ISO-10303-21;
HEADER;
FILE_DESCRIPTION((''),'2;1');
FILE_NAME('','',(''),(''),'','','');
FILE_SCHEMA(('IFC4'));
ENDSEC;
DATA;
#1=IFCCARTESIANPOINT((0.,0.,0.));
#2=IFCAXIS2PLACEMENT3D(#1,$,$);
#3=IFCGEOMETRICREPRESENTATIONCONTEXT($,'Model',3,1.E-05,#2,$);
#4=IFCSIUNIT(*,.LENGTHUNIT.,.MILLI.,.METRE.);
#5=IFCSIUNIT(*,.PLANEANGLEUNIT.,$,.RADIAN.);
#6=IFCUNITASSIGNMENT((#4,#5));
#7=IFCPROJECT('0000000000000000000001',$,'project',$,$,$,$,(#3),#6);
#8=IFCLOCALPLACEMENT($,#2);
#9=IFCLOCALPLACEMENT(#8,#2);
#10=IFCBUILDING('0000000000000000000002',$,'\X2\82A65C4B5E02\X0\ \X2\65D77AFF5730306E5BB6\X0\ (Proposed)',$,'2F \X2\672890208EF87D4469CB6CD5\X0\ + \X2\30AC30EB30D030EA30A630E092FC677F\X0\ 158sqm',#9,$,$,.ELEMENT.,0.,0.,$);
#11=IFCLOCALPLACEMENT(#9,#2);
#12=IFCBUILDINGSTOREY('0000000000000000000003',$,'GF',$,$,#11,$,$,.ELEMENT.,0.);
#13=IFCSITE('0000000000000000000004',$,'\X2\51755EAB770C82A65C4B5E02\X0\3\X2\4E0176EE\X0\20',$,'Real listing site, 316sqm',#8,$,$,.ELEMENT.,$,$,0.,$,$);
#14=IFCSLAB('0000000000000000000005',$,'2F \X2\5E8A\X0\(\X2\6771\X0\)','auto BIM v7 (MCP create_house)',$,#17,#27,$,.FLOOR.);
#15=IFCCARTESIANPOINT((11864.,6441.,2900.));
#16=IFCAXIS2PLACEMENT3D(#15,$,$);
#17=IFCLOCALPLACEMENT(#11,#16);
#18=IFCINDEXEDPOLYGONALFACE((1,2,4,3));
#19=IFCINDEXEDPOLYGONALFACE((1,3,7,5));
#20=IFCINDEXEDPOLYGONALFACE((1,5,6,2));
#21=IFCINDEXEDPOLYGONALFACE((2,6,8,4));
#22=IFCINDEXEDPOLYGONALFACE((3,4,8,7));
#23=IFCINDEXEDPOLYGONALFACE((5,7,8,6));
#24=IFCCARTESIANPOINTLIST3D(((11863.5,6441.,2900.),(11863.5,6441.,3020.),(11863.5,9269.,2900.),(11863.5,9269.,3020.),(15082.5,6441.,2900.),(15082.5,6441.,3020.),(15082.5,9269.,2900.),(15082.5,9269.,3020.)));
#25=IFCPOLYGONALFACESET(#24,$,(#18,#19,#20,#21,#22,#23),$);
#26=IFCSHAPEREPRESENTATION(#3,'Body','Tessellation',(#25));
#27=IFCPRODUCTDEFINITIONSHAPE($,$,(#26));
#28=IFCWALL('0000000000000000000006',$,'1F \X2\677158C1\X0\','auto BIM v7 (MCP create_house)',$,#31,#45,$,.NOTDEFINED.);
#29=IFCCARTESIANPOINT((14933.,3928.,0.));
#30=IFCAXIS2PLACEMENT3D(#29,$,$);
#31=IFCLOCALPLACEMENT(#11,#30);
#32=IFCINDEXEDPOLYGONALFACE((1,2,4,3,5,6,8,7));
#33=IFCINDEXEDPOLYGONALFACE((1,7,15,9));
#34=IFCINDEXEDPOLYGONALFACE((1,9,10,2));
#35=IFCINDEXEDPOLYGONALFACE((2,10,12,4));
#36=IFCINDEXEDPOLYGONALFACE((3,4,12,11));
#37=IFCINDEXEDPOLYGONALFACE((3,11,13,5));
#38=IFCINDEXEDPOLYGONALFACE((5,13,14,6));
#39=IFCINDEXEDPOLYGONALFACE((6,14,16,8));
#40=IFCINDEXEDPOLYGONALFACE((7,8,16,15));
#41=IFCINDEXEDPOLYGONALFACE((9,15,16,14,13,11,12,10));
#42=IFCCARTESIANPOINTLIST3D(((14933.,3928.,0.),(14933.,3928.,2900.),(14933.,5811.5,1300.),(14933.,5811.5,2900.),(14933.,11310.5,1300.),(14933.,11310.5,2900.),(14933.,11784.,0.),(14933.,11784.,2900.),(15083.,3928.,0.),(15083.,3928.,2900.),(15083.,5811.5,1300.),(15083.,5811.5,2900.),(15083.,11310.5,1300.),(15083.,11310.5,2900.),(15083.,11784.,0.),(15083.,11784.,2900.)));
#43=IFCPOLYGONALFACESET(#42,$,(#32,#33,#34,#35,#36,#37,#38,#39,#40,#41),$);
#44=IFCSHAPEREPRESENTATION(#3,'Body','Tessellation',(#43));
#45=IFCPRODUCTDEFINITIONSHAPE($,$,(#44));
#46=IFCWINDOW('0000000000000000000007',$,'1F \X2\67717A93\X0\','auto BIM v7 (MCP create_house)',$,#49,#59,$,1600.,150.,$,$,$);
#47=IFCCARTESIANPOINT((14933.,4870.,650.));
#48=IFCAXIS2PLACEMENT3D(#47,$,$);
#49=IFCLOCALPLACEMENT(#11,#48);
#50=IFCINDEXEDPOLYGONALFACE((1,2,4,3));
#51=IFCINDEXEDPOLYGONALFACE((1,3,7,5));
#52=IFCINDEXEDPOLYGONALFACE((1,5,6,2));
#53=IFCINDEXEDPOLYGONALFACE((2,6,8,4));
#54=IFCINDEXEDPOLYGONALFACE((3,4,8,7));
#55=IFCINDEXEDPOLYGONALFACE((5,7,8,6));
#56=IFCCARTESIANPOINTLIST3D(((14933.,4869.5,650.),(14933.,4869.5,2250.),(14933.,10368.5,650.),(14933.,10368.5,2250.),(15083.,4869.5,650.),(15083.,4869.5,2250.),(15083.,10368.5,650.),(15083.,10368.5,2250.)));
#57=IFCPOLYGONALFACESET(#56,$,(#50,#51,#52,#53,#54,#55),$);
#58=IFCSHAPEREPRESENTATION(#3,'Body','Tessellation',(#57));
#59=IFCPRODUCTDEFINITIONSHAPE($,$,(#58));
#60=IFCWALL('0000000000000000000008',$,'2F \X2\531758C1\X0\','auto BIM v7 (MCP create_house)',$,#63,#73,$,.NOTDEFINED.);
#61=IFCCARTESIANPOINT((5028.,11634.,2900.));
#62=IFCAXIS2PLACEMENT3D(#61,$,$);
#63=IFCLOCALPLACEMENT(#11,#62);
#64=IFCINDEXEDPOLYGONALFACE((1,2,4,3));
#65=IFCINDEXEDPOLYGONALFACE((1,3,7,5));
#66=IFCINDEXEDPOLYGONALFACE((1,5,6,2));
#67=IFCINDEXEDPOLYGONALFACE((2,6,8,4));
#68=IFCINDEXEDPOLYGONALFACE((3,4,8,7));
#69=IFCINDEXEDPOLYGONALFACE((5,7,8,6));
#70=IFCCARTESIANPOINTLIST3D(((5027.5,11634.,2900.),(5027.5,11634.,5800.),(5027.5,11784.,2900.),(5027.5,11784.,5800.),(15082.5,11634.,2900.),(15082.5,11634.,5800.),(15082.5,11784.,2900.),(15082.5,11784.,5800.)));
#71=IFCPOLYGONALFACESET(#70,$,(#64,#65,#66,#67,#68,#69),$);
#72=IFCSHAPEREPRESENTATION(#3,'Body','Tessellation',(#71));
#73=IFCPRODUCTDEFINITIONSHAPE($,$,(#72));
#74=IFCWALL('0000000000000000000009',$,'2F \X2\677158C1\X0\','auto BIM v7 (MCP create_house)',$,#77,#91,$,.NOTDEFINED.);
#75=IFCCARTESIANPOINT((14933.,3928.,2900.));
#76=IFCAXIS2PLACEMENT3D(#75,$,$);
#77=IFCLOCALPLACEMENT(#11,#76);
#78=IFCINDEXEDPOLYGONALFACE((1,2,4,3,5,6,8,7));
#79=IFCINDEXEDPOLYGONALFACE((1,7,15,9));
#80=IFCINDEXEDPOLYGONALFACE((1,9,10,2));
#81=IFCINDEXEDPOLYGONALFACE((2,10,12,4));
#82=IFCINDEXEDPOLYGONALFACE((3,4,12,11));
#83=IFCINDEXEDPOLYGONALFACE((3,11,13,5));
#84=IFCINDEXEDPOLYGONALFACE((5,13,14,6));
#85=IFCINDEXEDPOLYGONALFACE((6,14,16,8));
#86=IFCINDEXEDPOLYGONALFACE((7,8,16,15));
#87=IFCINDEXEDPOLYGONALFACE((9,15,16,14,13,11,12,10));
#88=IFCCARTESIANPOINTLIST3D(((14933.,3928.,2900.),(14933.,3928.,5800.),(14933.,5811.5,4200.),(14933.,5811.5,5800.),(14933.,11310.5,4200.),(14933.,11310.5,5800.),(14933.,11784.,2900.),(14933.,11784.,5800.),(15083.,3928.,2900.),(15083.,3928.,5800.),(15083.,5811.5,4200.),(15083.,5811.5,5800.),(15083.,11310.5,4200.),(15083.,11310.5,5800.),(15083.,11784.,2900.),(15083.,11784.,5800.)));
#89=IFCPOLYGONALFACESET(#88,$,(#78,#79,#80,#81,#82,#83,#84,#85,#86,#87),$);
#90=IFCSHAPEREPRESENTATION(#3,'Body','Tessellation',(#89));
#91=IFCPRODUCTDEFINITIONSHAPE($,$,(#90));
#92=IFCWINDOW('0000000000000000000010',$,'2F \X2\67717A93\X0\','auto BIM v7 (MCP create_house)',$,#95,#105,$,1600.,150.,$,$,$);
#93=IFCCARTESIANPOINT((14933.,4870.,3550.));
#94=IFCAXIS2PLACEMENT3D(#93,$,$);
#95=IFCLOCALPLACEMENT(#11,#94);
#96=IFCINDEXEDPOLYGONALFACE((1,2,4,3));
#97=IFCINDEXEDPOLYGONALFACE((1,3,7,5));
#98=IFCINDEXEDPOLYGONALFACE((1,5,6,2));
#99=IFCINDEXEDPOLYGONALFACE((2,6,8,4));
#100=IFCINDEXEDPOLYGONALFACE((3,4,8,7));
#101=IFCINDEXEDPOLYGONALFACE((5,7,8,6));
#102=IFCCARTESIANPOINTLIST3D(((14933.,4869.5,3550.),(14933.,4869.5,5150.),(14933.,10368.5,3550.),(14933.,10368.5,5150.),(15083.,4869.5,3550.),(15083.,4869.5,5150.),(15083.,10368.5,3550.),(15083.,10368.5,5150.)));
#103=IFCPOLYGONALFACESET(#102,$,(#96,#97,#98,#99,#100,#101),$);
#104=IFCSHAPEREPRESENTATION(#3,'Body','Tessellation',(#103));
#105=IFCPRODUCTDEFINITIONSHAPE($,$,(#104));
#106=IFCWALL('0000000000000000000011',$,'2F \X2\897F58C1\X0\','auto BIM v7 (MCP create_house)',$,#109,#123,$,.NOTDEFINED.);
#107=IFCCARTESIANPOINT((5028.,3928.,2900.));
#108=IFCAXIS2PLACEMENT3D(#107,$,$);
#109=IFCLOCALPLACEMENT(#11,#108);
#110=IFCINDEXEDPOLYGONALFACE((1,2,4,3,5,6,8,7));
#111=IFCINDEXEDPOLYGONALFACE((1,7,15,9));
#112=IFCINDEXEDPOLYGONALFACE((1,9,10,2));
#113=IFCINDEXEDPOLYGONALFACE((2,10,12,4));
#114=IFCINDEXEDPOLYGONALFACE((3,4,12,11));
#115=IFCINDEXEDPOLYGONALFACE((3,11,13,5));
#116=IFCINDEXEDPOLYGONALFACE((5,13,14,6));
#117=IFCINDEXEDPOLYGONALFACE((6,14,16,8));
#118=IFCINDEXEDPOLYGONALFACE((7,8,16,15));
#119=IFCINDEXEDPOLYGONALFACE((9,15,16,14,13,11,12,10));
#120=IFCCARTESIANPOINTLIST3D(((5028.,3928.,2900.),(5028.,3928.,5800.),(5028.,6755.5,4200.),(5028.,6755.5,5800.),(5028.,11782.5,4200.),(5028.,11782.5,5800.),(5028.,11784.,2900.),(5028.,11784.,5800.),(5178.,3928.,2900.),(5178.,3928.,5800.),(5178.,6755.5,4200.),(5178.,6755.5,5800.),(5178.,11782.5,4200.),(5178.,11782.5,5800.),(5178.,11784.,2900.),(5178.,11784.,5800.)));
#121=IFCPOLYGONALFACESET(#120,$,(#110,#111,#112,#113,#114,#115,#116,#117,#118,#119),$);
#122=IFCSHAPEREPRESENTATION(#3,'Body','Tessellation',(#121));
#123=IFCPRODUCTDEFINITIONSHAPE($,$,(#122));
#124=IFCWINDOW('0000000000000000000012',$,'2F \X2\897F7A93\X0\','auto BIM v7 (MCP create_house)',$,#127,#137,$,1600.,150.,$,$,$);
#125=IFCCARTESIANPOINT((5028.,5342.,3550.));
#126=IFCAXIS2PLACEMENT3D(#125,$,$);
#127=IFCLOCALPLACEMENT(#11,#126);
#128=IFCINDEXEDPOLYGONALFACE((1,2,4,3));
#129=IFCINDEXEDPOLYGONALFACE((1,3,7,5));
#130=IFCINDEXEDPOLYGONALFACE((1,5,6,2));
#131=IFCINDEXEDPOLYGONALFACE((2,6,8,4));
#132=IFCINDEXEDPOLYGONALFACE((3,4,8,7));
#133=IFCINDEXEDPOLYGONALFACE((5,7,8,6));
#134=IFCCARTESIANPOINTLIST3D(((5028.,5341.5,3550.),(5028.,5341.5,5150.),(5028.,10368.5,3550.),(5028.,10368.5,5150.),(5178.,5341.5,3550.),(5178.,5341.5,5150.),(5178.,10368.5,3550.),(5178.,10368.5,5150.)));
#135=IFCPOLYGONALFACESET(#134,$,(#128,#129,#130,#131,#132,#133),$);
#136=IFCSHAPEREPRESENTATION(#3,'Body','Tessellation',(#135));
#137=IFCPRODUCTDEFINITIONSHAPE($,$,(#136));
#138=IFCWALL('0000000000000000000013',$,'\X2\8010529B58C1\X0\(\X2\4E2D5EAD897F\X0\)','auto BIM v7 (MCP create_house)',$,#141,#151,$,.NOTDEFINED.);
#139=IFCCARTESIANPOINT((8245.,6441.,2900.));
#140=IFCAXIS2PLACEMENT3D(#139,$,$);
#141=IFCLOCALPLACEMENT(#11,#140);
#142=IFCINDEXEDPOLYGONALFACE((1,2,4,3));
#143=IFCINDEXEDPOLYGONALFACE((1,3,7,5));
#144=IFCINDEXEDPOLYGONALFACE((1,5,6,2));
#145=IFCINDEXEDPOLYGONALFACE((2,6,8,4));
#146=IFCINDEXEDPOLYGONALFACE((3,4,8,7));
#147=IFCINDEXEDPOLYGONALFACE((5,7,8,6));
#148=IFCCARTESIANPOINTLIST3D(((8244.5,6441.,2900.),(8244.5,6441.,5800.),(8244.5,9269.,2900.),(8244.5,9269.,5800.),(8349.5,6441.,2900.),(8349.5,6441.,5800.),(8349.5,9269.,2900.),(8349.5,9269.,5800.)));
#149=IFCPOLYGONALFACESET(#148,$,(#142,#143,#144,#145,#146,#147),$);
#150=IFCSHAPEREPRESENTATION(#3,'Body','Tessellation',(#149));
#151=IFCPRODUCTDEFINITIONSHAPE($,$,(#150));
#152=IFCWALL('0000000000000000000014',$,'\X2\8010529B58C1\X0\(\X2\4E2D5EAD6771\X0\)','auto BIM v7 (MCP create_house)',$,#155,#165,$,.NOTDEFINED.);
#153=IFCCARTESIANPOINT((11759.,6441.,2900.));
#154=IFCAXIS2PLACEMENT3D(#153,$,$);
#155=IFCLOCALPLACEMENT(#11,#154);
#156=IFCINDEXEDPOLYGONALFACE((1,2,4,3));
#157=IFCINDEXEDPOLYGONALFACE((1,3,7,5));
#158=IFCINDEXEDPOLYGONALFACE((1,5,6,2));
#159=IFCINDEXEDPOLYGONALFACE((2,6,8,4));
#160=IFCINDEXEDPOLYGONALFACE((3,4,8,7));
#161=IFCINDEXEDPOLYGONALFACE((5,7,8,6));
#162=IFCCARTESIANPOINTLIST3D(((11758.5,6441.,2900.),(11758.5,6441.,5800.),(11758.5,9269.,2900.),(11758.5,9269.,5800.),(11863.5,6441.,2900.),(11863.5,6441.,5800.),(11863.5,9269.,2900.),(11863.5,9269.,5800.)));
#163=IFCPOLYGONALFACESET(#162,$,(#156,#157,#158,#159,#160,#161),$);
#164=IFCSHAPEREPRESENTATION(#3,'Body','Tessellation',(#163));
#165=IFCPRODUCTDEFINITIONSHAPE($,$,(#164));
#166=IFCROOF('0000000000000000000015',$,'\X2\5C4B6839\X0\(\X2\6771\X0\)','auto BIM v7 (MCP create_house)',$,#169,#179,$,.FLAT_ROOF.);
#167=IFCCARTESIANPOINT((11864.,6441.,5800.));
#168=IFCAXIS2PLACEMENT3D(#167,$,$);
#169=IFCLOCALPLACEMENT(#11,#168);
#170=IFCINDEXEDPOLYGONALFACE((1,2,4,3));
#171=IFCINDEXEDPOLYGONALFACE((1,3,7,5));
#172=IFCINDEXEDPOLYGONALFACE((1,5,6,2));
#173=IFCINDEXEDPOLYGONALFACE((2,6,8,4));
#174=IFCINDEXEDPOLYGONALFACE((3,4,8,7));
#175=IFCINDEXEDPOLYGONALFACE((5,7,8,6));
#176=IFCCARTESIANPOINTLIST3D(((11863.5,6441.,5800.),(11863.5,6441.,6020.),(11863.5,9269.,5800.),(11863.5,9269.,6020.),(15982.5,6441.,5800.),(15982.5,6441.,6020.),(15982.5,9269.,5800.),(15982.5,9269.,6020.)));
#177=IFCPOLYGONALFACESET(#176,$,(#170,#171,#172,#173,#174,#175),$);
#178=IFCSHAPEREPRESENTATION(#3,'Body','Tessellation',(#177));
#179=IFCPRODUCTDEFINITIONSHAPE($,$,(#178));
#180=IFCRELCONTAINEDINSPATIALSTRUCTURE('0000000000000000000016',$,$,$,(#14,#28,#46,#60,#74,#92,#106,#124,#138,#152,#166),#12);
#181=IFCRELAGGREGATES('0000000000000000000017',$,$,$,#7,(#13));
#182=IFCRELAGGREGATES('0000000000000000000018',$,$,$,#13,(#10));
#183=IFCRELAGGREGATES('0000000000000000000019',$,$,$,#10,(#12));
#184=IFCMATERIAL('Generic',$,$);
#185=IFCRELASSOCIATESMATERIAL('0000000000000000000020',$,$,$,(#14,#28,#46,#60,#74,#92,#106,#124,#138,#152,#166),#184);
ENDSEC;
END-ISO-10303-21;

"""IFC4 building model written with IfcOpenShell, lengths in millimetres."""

from ifc_helpers import new_model, si_unit, frame, frame_2d, origin, place, context, project, spatial, rectangle, extrude, material, element, fill, save


model = new_model("IFC4")

# Units and contexts
model_context = context("Model", 3, precision=1e-05, world=origin())
ifc_project = project(units=[si_unit("LENGTHUNIT", "METRE", prefix="MILLI"), si_unit("PLANEANGLEUNIT", "RADIAN")], contexts=[model_context])

# Site, building, storey
site_placement = place(None, origin())
site = spatial("IfcSite", under=ifc_project, at=site_placement, Name="兵庫県芦屋市3丁目20", ObjectType="Real listing site, 316sqm", CompositionType="ELEMENT", RefElevation=0.0)
building_placement = place(site_placement, origin())
building = spatial("IfcBuilding", under=site, at=building_placement, Name="芦屋市 旗竿地の家 (Proposed)", ObjectType="2F 木造軸組構法 + ガルバリウム鋼板 158sqm", CompositionType="ELEMENT", ElevationOfRefHeight=0.0, ElevationOfTerrain=0.0)
storey_placement = place(building_placement, origin())
storey = spatial("IfcBuildingStorey", under=building, at=storey_placement, Name="GF", CompositionType="ELEMENT", Elevation=0.0)

# Slab
ifc_material = material(Name="Generic")
slab_1_placement = place(storey_placement, frame((11864.0, 6441.0, 2900.0)))
element("IfcSlab", 1, at=slab_1_placement, inside=storey, material=ifc_material, Name="2F 床(東)", Description="auto BIM v7 (MCP create_house)", PredefinedType="FLOOR", context=model_context, shape_type="SweptSolid", body=[
    extrude(rectangle(XDim=3219.0, YDim=2828.0, at=frame_2d((1609.0, 1414.0))), frame((11864.0, 6441.0, 2900.0)), (0.0, 0.0, 1.0), 120.0),
])

# Wall, opening, window
wall_1_placement = place(storey_placement, frame((14933.0, 3928.0, 0.0)))
wall_1 = element("IfcWall", 2, at=wall_1_placement, inside=storey, material=ifc_material, Name="1F 東壁", Description="auto BIM v7 (MCP create_house)", PredefinedType="NOTDEFINED", context=model_context, shape_type="SweptSolid", body=[
    extrude(rectangle(XDim=150.0, YDim=7856.0, at=frame_2d((75.0, 3928.0))), frame((14933.0, 3928.0, 0.0)), (0.0, 0.0, 1.0), 2900.0),
])
opening_1_placement = place(storey_placement, frame((14933.0, 4870.0, 650.0)))
opening_1 = element("IfcOpeningElement", 3, at=opening_1_placement, cuts=wall_1, PredefinedType="NOTDEFINED", context=model_context, shape_type="SweptSolid", body=[
    extrude(rectangle(XDim=150.0, YDim=5499.0, at=frame_2d((75.0, 2749.0))), frame((14933.0, 4870.0, 650.0)), (0.0, 0.0, 1.0), 1600.0),
])
window_1_placement = place(storey_placement, frame((14933.0, 4870.0, 650.0)))
window_1 = element("IfcWindow", 4, at=window_1_placement, inside=storey, material=ifc_material, Name="1F 東窓", Description="auto BIM v7 (MCP create_house)", OverallHeight=1600.0, OverallWidth=150.0, context=model_context, shape_type="SweptSolid", body=[
    extrude(rectangle(XDim=150.0, YDim=5499.0, at=frame_2d((75.0, 2749.0))), frame((14933.0, 4870.0, 650.0)), (0.0, 0.0, 1.0), 1600.0),
])
fill(opening_1, window_1)

# Wall
wall_2_placement = place(storey_placement, frame((5028.0, 11634.0, 2900.0)))
element("IfcWall", 5, at=wall_2_placement, inside=storey, material=ifc_material, Name="2F 北壁", Description="auto BIM v7 (MCP create_house)", PredefinedType="NOTDEFINED", context=model_context, shape_type="SweptSolid", body=[
    extrude(rectangle(XDim=10055.0, YDim=150.0, at=frame_2d((5027.0, 75.0))), frame((5028.0, 11634.0, 2900.0)), (0.0, 0.0, 1.0), 2900.0),
])

# Walls, openings, windows
wall_3_placement = place(storey_placement, frame((14933.0, 3928.0, 2900.0)))
wall_3 = element("IfcWall", 6, at=wall_3_placement, inside=storey, material=ifc_material, Name="2F 東壁", Description="auto BIM v7 (MCP create_house)", PredefinedType="NOTDEFINED", context=model_context, shape_type="SweptSolid", body=[
    extrude(rectangle(XDim=150.0, YDim=7856.0, at=frame_2d((75.0, 3928.0))), frame((14933.0, 3928.0, 2900.0)), (0.0, 0.0, 1.0), 2900.0),
])
opening_2_placement = place(storey_placement, frame((14933.0, 4870.0, 3550.0)))
opening_2 = element("IfcOpeningElement", 7, at=opening_2_placement, cuts=wall_3, PredefinedType="NOTDEFINED", context=model_context, shape_type="SweptSolid", body=[
    extrude(rectangle(XDim=150.0, YDim=5499.0, at=frame_2d((75.0, 2749.0))), frame((14933.0, 4870.0, 3550.0)), (0.0, 0.0, 1.0), 1600.0),
])
window_2_placement = place(storey_placement, frame((14933.0, 4870.0, 3550.0)))
window_2 = element("IfcWindow", 8, at=window_2_placement, inside=storey, material=ifc_material, Name="2F 東窓", Description="auto BIM v7 (MCP create_house)", OverallHeight=1600.0, OverallWidth=150.0, context=model_context, shape_type="SweptSolid", body=[
    extrude(rectangle(XDim=150.0, YDim=5499.0, at=frame_2d((75.0, 2749.0))), frame((14933.0, 4870.0, 3550.0)), (0.0, 0.0, 1.0), 1600.0),
])
fill(opening_2, window_2)
wall_4_placement = place(storey_placement, frame((5028.0, 3928.0, 2900.0)))
wall_4 = element("IfcWall", 9, at=wall_4_placement, inside=storey, material=ifc_material, Name="2F 西壁", Description="auto BIM v7 (MCP create_house)", PredefinedType="NOTDEFINED", context=model_context, shape_type="SweptSolid", body=[
    extrude(rectangle(XDim=150.0, YDim=7856.0, at=frame_2d((75.0, 3928.0))), frame((5028.0, 3928.0, 2900.0)), (0.0, 0.0, 1.0), 2900.0),
])
opening_3_placement = place(storey_placement, frame((5028.0, 5342.0, 3550.0)))
opening_3 = element("IfcOpeningElement", 10, at=opening_3_placement, cuts=wall_4, PredefinedType="NOTDEFINED", context=model_context, shape_type="SweptSolid", body=[
    extrude(rectangle(XDim=150.0, YDim=5027.0, at=frame_2d((75.0, 2513.0))), frame((5028.0, 5342.0, 3550.0)), (0.0, 0.0, 1.0), 1600.0),
])
window_3_placement = place(storey_placement, frame((5028.0, 5342.0, 3550.0)))
window_3 = element("IfcWindow", 11, at=window_3_placement, inside=storey, material=ifc_material, Name="2F 西窓", Description="auto BIM v7 (MCP create_house)", OverallHeight=1600.0, OverallWidth=150.0, context=model_context, shape_type="SweptSolid", body=[
    extrude(rectangle(XDim=150.0, YDim=5027.0, at=frame_2d((75.0, 2513.0))), frame((5028.0, 5342.0, 3550.0)), (0.0, 0.0, 1.0), 1600.0),
])
fill(opening_3, window_3)

# Walls
wall_5_placement = place(storey_placement, frame((8245.0, 6441.0, 2900.0)))
element("IfcWall", 12, at=wall_5_placement, inside=storey, material=ifc_material, Name="耐力壁(中庭西)", Description="auto BIM v7 (MCP create_house)", PredefinedType="NOTDEFINED", context=model_context, shape_type="SweptSolid", body=[
    extrude(rectangle(XDim=105.0, YDim=2828.0, at=frame_2d((52.0, 1414.0))), frame((8245.0, 6441.0, 2900.0)), (0.0, 0.0, 1.0), 2900.0),
])
wall_6_placement = place(storey_placement, frame((11759.0, 6441.0, 2900.0)))
element("IfcWall", 13, at=wall_6_placement, inside=storey, material=ifc_material, Name="耐力壁(中庭東)", Description="auto BIM v7 (MCP create_house)", PredefinedType="NOTDEFINED", context=model_context, shape_type="SweptSolid", body=[
    extrude(rectangle(XDim=105.0, YDim=2828.0, at=frame_2d((52.0, 1414.0))), frame((11759.0, 6441.0, 2900.0)), (0.0, 0.0, 1.0), 2900.0),
])

# Roof
for number, where, name in (
    (14, (11864.0, 6441.0, 5800.0), "屋根(東)"),
):
    element("IfcRoof", number, at=place(storey_placement, frame(where)), inside=storey, material=ifc_material, Name=name, Description="auto BIM v7 (MCP create_house)", PredefinedType="FLAT_ROOF", context=model_context, shape_type="SweptSolid", body=[
        extrude(rectangle(XDim=4119.0, YDim=2828.0, at=frame_2d((2059.0, 1414.0))), frame((11864.0, 6441.0, 5800.0)), (0.0, 0.0, 1.0), 220.0),
    ])

save(model, "model.ifc")
